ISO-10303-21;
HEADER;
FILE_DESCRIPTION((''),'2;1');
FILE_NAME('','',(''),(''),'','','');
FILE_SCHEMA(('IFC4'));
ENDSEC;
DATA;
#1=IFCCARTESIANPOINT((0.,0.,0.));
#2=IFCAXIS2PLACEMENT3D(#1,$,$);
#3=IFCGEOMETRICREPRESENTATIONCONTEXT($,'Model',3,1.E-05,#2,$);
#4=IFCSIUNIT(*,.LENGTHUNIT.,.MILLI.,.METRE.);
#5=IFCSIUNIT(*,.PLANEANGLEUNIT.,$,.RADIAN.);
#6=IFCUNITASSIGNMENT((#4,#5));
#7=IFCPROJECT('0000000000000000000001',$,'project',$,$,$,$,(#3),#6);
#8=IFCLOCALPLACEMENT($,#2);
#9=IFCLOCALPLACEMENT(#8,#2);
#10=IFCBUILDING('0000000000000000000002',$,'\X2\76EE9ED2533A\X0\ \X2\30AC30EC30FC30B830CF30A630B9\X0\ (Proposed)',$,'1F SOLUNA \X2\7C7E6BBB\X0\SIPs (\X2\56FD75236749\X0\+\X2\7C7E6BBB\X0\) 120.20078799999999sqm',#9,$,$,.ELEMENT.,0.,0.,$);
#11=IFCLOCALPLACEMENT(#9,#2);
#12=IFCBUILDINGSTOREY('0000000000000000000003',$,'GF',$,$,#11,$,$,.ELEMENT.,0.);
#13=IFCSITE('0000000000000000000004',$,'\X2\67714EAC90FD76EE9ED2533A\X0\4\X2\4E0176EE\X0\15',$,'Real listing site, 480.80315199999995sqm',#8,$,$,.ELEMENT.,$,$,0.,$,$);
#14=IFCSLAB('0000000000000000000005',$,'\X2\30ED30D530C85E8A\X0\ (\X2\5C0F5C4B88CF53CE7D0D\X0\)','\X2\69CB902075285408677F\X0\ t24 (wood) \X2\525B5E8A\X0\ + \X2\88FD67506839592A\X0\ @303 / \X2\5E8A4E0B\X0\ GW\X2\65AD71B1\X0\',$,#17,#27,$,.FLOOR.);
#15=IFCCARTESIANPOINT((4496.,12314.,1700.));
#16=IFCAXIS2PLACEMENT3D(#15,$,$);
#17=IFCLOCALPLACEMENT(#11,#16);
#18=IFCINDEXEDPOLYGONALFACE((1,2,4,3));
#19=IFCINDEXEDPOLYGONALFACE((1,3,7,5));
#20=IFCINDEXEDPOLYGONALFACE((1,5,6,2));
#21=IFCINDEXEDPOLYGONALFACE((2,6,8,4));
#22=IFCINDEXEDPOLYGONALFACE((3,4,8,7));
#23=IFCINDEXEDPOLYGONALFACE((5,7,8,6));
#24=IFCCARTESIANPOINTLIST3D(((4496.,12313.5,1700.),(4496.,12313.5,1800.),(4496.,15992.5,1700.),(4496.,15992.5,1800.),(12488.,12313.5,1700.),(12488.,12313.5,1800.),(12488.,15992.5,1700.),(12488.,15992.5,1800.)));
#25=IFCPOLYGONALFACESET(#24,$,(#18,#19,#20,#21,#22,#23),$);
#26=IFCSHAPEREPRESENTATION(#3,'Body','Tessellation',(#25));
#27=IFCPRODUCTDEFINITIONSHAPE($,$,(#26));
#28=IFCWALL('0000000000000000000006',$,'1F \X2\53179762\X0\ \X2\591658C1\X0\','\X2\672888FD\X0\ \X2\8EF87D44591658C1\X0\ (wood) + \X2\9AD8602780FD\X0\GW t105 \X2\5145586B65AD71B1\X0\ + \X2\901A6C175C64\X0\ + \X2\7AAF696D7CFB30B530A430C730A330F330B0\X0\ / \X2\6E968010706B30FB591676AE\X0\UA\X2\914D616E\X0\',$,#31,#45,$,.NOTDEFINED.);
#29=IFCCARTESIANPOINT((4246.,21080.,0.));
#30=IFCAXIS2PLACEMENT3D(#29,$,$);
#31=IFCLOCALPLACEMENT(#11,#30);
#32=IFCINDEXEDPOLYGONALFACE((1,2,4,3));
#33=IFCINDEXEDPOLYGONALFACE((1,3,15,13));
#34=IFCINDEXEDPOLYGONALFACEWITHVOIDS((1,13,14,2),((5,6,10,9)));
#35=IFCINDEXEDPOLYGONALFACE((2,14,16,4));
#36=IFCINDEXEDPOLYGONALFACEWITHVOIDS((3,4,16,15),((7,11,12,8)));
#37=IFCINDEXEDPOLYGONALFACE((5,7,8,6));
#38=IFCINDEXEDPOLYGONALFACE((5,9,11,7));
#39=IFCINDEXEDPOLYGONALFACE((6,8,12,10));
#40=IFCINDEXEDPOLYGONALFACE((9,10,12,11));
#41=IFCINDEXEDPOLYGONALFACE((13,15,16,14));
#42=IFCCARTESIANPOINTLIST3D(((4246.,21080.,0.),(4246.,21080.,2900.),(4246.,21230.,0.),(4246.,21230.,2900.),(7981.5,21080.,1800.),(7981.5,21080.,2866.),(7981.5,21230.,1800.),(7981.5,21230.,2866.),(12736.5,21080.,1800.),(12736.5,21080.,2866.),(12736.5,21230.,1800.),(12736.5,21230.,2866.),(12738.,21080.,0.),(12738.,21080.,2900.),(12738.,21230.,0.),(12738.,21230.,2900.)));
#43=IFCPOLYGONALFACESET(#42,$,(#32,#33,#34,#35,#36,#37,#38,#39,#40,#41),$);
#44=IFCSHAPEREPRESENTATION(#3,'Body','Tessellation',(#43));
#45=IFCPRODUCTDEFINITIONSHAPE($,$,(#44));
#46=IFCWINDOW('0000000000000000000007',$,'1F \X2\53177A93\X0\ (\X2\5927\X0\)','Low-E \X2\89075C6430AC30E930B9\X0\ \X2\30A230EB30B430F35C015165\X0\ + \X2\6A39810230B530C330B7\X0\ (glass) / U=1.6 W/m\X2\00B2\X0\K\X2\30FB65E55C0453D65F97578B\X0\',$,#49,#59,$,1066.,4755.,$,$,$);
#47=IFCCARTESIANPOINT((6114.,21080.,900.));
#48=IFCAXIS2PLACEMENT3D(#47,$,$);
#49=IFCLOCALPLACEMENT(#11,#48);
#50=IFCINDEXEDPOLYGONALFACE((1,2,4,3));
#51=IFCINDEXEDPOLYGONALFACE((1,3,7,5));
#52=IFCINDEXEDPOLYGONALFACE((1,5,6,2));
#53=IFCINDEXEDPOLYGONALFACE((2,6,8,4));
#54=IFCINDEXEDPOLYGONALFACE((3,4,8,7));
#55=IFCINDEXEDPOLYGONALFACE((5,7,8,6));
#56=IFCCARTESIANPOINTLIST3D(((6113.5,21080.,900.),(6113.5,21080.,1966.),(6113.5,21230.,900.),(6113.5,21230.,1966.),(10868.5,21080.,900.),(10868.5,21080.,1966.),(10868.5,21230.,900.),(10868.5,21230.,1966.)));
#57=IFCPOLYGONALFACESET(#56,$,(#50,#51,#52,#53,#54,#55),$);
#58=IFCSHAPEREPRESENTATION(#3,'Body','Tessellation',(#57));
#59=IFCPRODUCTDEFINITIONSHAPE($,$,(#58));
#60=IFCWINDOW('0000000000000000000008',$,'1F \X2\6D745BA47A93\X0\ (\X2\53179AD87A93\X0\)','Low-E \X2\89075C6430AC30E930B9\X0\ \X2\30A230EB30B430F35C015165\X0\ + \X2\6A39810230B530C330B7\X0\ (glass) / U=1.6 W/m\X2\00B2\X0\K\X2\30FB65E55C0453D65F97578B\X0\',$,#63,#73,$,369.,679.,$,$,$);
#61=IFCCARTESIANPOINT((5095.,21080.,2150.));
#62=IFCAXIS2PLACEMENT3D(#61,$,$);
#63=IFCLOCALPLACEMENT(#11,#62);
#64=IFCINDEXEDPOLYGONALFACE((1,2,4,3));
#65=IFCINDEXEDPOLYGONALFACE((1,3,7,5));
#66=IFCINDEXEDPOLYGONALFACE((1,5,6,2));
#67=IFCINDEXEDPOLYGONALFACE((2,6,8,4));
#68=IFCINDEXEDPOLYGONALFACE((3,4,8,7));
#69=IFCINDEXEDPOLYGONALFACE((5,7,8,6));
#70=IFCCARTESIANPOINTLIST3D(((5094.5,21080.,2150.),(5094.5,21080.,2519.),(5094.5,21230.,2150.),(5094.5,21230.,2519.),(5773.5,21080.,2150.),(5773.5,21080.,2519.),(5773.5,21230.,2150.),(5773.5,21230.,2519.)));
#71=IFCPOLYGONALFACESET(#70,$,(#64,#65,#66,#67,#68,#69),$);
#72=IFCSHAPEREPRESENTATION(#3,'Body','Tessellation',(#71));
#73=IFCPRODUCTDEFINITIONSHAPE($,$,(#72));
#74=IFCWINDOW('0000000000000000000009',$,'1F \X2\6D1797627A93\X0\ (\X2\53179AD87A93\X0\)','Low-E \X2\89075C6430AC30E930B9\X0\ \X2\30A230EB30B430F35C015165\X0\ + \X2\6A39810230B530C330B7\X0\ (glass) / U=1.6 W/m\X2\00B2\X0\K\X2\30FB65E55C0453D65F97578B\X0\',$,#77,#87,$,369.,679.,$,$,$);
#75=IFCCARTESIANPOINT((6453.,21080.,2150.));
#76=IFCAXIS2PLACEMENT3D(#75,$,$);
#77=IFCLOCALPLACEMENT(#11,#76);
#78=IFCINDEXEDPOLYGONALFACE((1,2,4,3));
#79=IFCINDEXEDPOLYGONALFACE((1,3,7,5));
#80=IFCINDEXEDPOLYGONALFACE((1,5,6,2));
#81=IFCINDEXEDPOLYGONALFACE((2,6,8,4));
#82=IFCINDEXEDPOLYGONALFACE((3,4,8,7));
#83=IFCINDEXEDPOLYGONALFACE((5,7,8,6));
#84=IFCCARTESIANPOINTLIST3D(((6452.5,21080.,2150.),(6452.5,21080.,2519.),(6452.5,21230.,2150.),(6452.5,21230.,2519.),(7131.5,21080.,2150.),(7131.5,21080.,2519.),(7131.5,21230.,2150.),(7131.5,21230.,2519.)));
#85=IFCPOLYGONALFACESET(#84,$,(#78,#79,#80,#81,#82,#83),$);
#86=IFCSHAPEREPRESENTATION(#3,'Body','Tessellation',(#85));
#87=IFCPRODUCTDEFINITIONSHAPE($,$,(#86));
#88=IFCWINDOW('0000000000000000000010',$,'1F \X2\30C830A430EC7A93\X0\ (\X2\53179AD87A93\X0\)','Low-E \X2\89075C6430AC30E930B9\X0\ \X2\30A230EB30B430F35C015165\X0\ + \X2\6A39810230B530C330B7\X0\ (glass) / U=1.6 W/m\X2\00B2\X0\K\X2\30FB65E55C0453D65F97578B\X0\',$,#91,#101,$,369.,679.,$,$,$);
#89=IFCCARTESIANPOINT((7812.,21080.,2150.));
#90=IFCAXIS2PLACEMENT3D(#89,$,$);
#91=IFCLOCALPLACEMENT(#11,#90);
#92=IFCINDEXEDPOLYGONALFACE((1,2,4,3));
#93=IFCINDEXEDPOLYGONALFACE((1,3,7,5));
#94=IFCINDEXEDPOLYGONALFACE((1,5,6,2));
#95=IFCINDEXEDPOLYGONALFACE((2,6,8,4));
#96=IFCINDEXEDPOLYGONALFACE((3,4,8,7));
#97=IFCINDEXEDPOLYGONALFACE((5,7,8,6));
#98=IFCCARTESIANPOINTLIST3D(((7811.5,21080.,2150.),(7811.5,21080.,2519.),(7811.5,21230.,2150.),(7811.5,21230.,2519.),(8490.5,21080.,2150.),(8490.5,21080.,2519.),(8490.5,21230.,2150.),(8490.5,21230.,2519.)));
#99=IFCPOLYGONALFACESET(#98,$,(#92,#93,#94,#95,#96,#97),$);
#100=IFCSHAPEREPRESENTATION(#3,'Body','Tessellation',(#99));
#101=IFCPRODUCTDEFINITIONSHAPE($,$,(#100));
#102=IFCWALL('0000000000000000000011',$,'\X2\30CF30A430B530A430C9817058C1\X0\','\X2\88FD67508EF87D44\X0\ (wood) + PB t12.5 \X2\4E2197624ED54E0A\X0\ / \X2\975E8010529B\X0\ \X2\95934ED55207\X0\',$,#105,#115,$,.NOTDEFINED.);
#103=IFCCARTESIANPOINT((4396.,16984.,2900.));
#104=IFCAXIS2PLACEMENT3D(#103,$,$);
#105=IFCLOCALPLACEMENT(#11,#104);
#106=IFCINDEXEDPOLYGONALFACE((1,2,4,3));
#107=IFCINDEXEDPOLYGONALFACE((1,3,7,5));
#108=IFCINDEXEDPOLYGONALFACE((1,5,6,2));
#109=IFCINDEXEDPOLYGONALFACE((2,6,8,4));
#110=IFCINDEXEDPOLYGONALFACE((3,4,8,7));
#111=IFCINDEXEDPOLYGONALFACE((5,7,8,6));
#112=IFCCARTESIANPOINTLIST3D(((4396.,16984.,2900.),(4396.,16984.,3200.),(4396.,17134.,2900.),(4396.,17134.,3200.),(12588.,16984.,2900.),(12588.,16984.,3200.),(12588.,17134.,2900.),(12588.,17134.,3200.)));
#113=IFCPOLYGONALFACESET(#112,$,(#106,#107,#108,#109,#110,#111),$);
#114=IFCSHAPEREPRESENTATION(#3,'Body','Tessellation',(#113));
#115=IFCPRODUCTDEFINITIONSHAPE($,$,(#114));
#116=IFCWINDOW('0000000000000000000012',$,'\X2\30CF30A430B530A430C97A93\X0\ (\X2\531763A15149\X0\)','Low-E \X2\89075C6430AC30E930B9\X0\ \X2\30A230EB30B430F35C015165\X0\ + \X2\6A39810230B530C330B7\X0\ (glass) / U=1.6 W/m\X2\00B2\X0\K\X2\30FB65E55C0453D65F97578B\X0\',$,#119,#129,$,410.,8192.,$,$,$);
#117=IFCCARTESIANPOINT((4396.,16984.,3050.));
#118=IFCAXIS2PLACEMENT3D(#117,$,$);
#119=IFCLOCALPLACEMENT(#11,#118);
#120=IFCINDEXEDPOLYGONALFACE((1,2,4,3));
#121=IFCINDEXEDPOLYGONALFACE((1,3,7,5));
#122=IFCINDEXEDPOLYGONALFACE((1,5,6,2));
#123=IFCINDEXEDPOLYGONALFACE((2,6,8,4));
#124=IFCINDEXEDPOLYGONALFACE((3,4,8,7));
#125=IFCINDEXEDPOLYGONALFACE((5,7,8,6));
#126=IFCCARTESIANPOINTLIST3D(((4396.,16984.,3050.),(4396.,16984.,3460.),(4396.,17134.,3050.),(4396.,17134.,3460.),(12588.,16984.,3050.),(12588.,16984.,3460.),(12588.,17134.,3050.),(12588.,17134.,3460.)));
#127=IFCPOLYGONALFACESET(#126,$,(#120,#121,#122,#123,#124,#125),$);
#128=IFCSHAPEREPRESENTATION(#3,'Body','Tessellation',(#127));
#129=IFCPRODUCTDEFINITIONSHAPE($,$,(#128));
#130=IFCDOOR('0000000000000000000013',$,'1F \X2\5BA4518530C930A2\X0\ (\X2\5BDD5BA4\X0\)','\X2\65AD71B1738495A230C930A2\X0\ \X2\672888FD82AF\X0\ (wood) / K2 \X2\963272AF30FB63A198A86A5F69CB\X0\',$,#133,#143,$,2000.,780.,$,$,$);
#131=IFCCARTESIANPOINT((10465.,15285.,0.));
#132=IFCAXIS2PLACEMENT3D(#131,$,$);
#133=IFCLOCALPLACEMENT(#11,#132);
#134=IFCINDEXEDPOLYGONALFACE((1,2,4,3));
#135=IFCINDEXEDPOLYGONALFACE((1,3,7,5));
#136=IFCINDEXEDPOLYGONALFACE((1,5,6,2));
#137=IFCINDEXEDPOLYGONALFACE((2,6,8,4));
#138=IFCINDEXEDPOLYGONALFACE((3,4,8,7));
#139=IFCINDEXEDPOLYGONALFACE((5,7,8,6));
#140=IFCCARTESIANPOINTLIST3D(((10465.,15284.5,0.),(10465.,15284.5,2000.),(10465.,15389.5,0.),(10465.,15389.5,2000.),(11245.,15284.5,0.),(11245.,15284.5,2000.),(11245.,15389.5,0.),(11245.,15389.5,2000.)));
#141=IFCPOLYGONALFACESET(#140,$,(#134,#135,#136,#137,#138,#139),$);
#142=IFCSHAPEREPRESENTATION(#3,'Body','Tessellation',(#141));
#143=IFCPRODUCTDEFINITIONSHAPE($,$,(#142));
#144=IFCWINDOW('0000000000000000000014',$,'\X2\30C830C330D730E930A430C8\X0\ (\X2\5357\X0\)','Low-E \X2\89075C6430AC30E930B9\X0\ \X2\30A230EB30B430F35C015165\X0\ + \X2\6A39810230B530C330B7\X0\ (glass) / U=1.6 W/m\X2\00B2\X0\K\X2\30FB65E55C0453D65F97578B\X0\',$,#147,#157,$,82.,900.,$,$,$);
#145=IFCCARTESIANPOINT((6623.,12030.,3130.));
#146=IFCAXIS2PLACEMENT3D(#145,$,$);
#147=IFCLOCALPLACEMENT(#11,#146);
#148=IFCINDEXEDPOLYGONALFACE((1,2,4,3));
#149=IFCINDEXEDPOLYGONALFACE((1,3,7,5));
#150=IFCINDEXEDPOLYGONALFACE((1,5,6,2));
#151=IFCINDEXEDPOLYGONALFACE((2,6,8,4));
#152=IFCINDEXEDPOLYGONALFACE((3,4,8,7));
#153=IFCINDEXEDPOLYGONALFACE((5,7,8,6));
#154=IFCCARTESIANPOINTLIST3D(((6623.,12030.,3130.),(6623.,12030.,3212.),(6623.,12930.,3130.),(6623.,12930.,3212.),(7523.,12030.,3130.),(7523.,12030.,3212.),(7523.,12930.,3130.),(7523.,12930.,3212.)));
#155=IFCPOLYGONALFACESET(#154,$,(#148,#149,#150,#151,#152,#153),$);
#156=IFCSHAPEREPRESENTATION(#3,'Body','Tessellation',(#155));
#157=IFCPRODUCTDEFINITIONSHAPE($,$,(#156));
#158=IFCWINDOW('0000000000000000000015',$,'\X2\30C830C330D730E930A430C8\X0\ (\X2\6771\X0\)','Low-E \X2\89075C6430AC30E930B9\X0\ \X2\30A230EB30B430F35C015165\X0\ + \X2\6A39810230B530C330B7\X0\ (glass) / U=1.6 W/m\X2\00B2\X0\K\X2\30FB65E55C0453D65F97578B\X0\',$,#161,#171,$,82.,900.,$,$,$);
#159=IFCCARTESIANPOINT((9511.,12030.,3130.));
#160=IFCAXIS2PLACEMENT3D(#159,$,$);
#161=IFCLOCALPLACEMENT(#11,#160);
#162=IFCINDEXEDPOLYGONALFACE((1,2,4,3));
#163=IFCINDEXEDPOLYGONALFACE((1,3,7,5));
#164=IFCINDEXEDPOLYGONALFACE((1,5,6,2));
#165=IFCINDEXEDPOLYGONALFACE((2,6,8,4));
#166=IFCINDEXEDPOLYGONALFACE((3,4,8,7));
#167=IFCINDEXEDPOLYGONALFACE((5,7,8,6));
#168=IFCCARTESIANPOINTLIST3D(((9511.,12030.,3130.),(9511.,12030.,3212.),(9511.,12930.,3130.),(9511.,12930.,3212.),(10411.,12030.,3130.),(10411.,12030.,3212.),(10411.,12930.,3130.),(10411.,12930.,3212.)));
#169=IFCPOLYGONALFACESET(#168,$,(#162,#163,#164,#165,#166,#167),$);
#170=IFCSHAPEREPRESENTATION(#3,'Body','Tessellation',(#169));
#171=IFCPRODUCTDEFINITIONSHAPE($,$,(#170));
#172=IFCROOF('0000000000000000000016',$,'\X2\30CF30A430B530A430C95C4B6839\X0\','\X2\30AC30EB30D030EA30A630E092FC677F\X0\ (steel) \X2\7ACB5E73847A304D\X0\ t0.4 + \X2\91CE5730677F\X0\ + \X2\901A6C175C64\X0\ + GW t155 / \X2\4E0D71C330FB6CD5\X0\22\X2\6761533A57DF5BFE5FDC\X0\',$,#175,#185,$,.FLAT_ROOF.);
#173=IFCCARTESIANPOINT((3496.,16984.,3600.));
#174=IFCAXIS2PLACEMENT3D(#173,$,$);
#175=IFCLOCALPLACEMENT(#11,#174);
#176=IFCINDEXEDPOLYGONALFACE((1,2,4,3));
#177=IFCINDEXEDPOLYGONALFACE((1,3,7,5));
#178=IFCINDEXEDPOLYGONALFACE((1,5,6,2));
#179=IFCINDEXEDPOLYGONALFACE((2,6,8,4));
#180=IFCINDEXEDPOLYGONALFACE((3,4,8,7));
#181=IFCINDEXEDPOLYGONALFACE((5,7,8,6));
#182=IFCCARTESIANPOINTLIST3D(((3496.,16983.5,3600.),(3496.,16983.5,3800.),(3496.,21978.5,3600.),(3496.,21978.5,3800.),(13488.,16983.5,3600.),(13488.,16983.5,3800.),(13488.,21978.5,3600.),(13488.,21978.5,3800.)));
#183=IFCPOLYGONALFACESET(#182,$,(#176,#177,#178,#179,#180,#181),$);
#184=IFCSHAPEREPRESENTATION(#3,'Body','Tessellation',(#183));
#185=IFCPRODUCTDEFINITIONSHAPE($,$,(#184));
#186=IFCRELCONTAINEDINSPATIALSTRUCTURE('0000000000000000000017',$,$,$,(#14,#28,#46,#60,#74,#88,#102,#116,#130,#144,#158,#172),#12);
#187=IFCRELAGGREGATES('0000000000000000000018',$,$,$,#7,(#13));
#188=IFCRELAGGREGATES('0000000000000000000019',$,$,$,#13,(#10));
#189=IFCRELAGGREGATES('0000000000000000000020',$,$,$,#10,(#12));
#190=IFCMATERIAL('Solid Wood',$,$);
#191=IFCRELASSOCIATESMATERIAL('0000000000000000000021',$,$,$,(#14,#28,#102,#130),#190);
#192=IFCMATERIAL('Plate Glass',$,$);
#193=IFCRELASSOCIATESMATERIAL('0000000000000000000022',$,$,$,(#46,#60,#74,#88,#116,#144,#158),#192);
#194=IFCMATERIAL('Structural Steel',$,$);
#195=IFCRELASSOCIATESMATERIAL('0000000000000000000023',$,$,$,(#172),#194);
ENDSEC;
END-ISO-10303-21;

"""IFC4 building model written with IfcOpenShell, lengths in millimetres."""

from ifc_helpers import new_model, si_unit, frame, frame_2d, origin, place, context, project, spatial, rectangle, extrude, material, element, fill, save


model = new_model("IFC4")

# Units and contexts
model_context = context("Model", 3, precision=1e-05, world=origin())
ifc_project = project(units=[si_unit("LENGTHUNIT", "METRE", prefix="MILLI"), si_unit("PLANEANGLEUNIT", "RADIAN")], contexts=[model_context])

# Site, building, storey
site_placement = place(None, origin())
site = spatial("IfcSite", under=ifc_project, at=site_placement, Name="東京都目黒区4丁目15", ObjectType="Real listing site, 480.80315199999995sqm", CompositionType="ELEMENT", RefElevation=0.0)
building_placement = place(site_placement, origin())
building = spatial("IfcBuilding", under=site, at=building_placement, Name="目黒区 ガレージハウス (Proposed)", ObjectType="1F SOLUNA 籾殻SIPs (国産杉+籾殻) 120.20078799999999sqm", CompositionType="ELEMENT", ElevationOfRefHeight=0.0, ElevationOfTerrain=0.0)
storey_placement = place(building_placement, origin())
storey = spatial("IfcBuildingStorey", under=building, at=storey_placement, Name="GF", CompositionType="ELEMENT", Elevation=0.0)

# Slab
ifc_material_1 = material(Name="Solid Wood")
slab_placement = place(storey_placement, frame((4496.0, 12314.0, 1700.0)))
element("IfcSlab", 1, at=slab_placement, inside=storey, material=ifc_material_1, Name="ロフト床 (小屋裏収納)", Description="構造用合板 t24 (wood) 剛床 + 製材根太 @303 / 床下 GW断熱", PredefinedType="FLOOR", context=model_context, shape_type="SweptSolid", body=[
    extrude(rectangle(XDim=7992.0, YDim=3679.0, at=frame_2d((3996.0, 1839.0))), frame((4496.0, 12314.0, 1700.0)), (0.0, 0.0, 1.0), 100.0),
])

# Wall, openings, windows
wall_1_placement = place(storey_placement, frame((4246.0, 21080.0, 0.0)))
wall_1 = element("IfcWall", 2, at=wall_1_placement, inside=storey, material=ifc_material_1, Name="1F 北面 外壁", Description="木製 軸組外壁 (wood) + 高性能GW t105 充填断熱 + 通気層 + 窯業系サイディング / 準耐火・外皮UA配慮", PredefinedType="NOTDEFINED", context=model_context, shape_type="SweptSolid", body=[
    extrude(rectangle(XDim=8492.0, YDim=150.0, at=frame_2d((4246.0, 75.0))), frame((4246.0, 21080.0, 0.0)), (0.0, 0.0, 1.0), 2900.0),
])
opening_1_placement = place(storey_placement, frame((6114.0, 21080.0, 900.0)))
opening_1 = element("IfcOpeningElement", 3, at=opening_1_placement, cuts=wall_1, PredefinedType="NOTDEFINED", context=model_context, shape_type="SweptSolid", body=[
    extrude(rectangle(XDim=4755.0, YDim=150.0, at=frame_2d((2377.0, 75.0))), frame((6114.0, 21080.0, 900.0)), (0.0, 0.0, 1.0), 1066.0),
])
opening_2_placement = place(storey_placement, frame((5095.0, 21080.0, 2150.0)))
opening_2 = element("IfcOpeningElement", 4, at=opening_2_placement, cuts=wall_1, PredefinedType="NOTDEFINED", context=model_context, shape_type="SweptSolid", body=[
    extrude(rectangle(XDim=679.0, YDim=150.0, at=frame_2d((339.0, 75.0))), frame((5095.0, 21080.0, 2150.0)), (0.0, 0.0, 1.0), 369.0),
])
opening_3_placement = place(storey_placement, frame((6453.0, 21080.0, 2150.0)))
opening_3 = element("IfcOpeningElement", 5, at=opening_3_placement, cuts=wall_1, PredefinedType="NOTDEFINED", context=model_context, shape_type="SweptSolid", body=[
    extrude(rectangle(XDim=679.0, YDim=150.0, at=frame_2d((339.0, 75.0))), frame((6453.0, 21080.0, 2150.0)), (0.0, 0.0, 1.0), 369.0),
])
opening_4_placement = place(storey_placement, frame((7812.0, 21080.0, 2150.0)))
opening_4 = element("IfcOpeningElement", 6, at=opening_4_placement, cuts=wall_1, PredefinedType="NOTDEFINED", context=model_context, shape_type="SweptSolid", body=[
    extrude(rectangle(XDim=679.0, YDim=150.0, at=frame_2d((339.0, 75.0))), frame((7812.0, 21080.0, 2150.0)), (0.0, 0.0, 1.0), 369.0),
])
ifc_material_2 = material(Name="Plate Glass")
window_1_placement = place(storey_placement, frame((6114.0, 21080.0, 900.0)))
window_1 = element("IfcWindow", 7, at=window_1_placement, inside=storey, material=ifc_material_2, Name="1F 北窓 (大)", Description="Low-E 複層ガラス アルゴン封入 + 樹脂サッシ (glass) / U=1.6 W/m²K・日射取得型", OverallHeight=1066.0, OverallWidth=4755.0, context=model_context, shape_type="SweptSolid", body=[
    extrude(rectangle(XDim=4755.0, YDim=150.0, at=frame_2d((2377.0, 75.0))), frame((6114.0, 21080.0, 900.0)), (0.0, 0.0, 1.0), 1066.0),
])
fill(opening_1, window_1)
window_2_placement = place(storey_placement, frame((5095.0, 21080.0, 2150.0)))
window_2 = element("IfcWindow", 8, at=window_2_placement, inside=storey, material=ifc_material_2, Name="1F 浴室窓 (北高窓)", Description="Low-E 複層ガラス アルゴン封入 + 樹脂サッシ (glass) / U=1.6 W/m²K・日射取得型", OverallHeight=369.0, OverallWidth=679.0, context=model_context, shape_type="SweptSolid", body=[
    extrude(rectangle(XDim=679.0, YDim=150.0, at=frame_2d((339.0, 75.0))), frame((5095.0, 21080.0, 2150.0)), (0.0, 0.0, 1.0), 369.0),
])
fill(opening_2, window_2)
window_3_placement = place(storey_placement, frame((6453.0, 21080.0, 2150.0)))
window_3 = element("IfcWindow", 9, at=window_3_placement, inside=storey, material=ifc_material_2, Name="1F 洗面窓 (北高窓)", Description="Low-E 複層ガラス アルゴン封入 + 樹脂サッシ (glass) / U=1.6 W/m²K・日射取得型", OverallHeight=369.0, OverallWidth=679.0, context=model_context, shape_type="SweptSolid", body=[
    extrude(rectangle(XDim=679.0, YDim=150.0, at=frame_2d((339.0, 75.0))), frame((6453.0, 21080.0, 2150.0)), (0.0, 0.0, 1.0), 369.0),
])
fill(opening_3, window_3)
window_4_placement = place(storey_placement, frame((7812.0, 21080.0, 2150.0)))
window_4 = element("IfcWindow", 10, at=window_4_placement, inside=storey, material=ifc_material_2, Name="1F トイレ窓 (北高窓)", Description="Low-E 複層ガラス アルゴン封入 + 樹脂サッシ (glass) / U=1.6 W/m²K・日射取得型", OverallHeight=369.0, OverallWidth=679.0, context=model_context, shape_type="SweptSolid", body=[
    extrude(rectangle(XDim=679.0, YDim=150.0, at=frame_2d((339.0, 75.0))), frame((7812.0, 21080.0, 2150.0)), (0.0, 0.0, 1.0), 369.0),
])
fill(opening_4, window_4)

# Wall, opening, window
wall_2_placement = place(storey_placement, frame((4396.0, 16984.0, 2900.0)))
wall_2 = element("IfcWall", 11, at=wall_2_placement, inside=storey, material=ifc_material_1, Name="ハイサイド腰壁", Description="製材軸組 (wood) + PB t12.5 両面仕上 / 非耐力 間仕切", PredefinedType="NOTDEFINED", context=model_context, shape_type="SweptSolid", body=[
    extrude(rectangle(XDim=8192.0, YDim=150.0, at=frame_2d((4096.0, 75.0))), frame((4396.0, 16984.0, 2900.0)), (0.0, 0.0, 1.0), 700.0),
])
opening_5_placement = place(storey_placement, frame((4396.0, 16984.0, 3050.0)))
opening_5 = element("IfcOpeningElement", 12, at=opening_5_placement, cuts=wall_2, PredefinedType="NOTDEFINED", context=model_context, shape_type="SweptSolid", body=[
    extrude(rectangle(XDim=8192.0, YDim=150.0, at=frame_2d((4096.0, 75.0))), frame((4396.0, 16984.0, 3050.0)), (0.0, 0.0, 1.0), 410.0),
])
window_5_placement = place(storey_placement, frame((4396.0, 16984.0, 3050.0)))
window_5 = element("IfcWindow", 13, at=window_5_placement, inside=storey, material=ifc_material_2, Name="ハイサイド窓 (北採光)", Description="Low-E 複層ガラス アルゴン封入 + 樹脂サッシ (glass) / U=1.6 W/m²K・日射取得型", OverallHeight=410.0, OverallWidth=8192.0, context=model_context, shape_type="SweptSolid", body=[
    extrude(rectangle(XDim=8192.0, YDim=150.0, at=frame_2d((4096.0, 75.0))), frame((4396.0, 16984.0, 3050.0)), (0.0, 0.0, 1.0), 410.0),
])
fill(opening_5, window_5)

# Door
door_1_placement = place(storey_placement, frame((10465.0, 15285.0, 0.0)))
element("IfcDoor", 14, at=door_1_placement, inside=storey, material=ifc_material_1, Name="1F 室内ドア (寝室)", Description="断熱玄関ドア 木製芯 (wood) / K2 防犯・採風機構", OverallHeight=2000.0, OverallWidth=780.0, context=model_context, shape_type="SweptSolid", body=[
    extrude(rectangle(XDim=780.0, YDim=105.0, at=frame_2d((390.0, 52.0))), frame((10465.0, 15285.0, 0.0)), (0.0, 0.0, 1.0), 2000.0),
])

# Windows
window_6_placement = place(storey_placement, frame((6623.0, 12030.0, 3130.0)))
element("IfcWindow", 15, at=window_6_placement, inside=storey, material=ifc_material_2, Name="トップライト (南)", Description="Low-E 複層ガラス アルゴン封入 + 樹脂サッシ (glass) / U=1.6 W/m²K・日射取得型", OverallHeight=82.0, OverallWidth=900.0, context=model_context, shape_type="SweptSolid", body=[
    extrude(rectangle(XDim=900.0, YDim=900.0, at=frame_2d((450.0, 450.0))), frame((6623.0, 12030.0, 3130.0)), (0.0, 0.0, 1.0), 82.0),
])
window_7_placement = place(storey_placement, frame((9511.0, 12030.0, 3130.0)))
element("IfcWindow", 16, at=window_7_placement, inside=storey, material=ifc_material_2, Name="トップライト (東)", Description="Low-E 複層ガラス アルゴン封入 + 樹脂サッシ (glass) / U=1.6 W/m²K・日射取得型", OverallHeight=82.0, OverallWidth=900.0, context=model_context, shape_type="SweptSolid", body=[
    extrude(rectangle(XDim=900.0, YDim=900.0, at=frame_2d((450.0, 450.0))), frame((9511.0, 12030.0, 3130.0)), (0.0, 0.0, 1.0), 82.0),
])

# Roof
ifc_material_3 = material(Name="Structural Steel")
roof_placement = place(storey_placement, frame((3496.0, 16984.0, 3600.0)))
element("IfcRoof", 17, at=roof_placement, inside=storey, material=ifc_material_3, Name="ハイサイド屋根", Description="ガルバリウム鋼板 (steel) 立平葺き t0.4 + 野地板 + 通気層 + GW t155 / 不燃・法22条区域対応", PredefinedType="FLAT_ROOF", context=model_context, shape_type="SweptSolid", body=[
    extrude(rectangle(XDim=9992.0, YDim=4995.0, at=frame_2d((4996.0, 2497.0))), frame((3496.0, 16984.0, 3600.0)), (0.0, 0.0, 1.0), 200.0),
])

save(model, "model.ifc")
